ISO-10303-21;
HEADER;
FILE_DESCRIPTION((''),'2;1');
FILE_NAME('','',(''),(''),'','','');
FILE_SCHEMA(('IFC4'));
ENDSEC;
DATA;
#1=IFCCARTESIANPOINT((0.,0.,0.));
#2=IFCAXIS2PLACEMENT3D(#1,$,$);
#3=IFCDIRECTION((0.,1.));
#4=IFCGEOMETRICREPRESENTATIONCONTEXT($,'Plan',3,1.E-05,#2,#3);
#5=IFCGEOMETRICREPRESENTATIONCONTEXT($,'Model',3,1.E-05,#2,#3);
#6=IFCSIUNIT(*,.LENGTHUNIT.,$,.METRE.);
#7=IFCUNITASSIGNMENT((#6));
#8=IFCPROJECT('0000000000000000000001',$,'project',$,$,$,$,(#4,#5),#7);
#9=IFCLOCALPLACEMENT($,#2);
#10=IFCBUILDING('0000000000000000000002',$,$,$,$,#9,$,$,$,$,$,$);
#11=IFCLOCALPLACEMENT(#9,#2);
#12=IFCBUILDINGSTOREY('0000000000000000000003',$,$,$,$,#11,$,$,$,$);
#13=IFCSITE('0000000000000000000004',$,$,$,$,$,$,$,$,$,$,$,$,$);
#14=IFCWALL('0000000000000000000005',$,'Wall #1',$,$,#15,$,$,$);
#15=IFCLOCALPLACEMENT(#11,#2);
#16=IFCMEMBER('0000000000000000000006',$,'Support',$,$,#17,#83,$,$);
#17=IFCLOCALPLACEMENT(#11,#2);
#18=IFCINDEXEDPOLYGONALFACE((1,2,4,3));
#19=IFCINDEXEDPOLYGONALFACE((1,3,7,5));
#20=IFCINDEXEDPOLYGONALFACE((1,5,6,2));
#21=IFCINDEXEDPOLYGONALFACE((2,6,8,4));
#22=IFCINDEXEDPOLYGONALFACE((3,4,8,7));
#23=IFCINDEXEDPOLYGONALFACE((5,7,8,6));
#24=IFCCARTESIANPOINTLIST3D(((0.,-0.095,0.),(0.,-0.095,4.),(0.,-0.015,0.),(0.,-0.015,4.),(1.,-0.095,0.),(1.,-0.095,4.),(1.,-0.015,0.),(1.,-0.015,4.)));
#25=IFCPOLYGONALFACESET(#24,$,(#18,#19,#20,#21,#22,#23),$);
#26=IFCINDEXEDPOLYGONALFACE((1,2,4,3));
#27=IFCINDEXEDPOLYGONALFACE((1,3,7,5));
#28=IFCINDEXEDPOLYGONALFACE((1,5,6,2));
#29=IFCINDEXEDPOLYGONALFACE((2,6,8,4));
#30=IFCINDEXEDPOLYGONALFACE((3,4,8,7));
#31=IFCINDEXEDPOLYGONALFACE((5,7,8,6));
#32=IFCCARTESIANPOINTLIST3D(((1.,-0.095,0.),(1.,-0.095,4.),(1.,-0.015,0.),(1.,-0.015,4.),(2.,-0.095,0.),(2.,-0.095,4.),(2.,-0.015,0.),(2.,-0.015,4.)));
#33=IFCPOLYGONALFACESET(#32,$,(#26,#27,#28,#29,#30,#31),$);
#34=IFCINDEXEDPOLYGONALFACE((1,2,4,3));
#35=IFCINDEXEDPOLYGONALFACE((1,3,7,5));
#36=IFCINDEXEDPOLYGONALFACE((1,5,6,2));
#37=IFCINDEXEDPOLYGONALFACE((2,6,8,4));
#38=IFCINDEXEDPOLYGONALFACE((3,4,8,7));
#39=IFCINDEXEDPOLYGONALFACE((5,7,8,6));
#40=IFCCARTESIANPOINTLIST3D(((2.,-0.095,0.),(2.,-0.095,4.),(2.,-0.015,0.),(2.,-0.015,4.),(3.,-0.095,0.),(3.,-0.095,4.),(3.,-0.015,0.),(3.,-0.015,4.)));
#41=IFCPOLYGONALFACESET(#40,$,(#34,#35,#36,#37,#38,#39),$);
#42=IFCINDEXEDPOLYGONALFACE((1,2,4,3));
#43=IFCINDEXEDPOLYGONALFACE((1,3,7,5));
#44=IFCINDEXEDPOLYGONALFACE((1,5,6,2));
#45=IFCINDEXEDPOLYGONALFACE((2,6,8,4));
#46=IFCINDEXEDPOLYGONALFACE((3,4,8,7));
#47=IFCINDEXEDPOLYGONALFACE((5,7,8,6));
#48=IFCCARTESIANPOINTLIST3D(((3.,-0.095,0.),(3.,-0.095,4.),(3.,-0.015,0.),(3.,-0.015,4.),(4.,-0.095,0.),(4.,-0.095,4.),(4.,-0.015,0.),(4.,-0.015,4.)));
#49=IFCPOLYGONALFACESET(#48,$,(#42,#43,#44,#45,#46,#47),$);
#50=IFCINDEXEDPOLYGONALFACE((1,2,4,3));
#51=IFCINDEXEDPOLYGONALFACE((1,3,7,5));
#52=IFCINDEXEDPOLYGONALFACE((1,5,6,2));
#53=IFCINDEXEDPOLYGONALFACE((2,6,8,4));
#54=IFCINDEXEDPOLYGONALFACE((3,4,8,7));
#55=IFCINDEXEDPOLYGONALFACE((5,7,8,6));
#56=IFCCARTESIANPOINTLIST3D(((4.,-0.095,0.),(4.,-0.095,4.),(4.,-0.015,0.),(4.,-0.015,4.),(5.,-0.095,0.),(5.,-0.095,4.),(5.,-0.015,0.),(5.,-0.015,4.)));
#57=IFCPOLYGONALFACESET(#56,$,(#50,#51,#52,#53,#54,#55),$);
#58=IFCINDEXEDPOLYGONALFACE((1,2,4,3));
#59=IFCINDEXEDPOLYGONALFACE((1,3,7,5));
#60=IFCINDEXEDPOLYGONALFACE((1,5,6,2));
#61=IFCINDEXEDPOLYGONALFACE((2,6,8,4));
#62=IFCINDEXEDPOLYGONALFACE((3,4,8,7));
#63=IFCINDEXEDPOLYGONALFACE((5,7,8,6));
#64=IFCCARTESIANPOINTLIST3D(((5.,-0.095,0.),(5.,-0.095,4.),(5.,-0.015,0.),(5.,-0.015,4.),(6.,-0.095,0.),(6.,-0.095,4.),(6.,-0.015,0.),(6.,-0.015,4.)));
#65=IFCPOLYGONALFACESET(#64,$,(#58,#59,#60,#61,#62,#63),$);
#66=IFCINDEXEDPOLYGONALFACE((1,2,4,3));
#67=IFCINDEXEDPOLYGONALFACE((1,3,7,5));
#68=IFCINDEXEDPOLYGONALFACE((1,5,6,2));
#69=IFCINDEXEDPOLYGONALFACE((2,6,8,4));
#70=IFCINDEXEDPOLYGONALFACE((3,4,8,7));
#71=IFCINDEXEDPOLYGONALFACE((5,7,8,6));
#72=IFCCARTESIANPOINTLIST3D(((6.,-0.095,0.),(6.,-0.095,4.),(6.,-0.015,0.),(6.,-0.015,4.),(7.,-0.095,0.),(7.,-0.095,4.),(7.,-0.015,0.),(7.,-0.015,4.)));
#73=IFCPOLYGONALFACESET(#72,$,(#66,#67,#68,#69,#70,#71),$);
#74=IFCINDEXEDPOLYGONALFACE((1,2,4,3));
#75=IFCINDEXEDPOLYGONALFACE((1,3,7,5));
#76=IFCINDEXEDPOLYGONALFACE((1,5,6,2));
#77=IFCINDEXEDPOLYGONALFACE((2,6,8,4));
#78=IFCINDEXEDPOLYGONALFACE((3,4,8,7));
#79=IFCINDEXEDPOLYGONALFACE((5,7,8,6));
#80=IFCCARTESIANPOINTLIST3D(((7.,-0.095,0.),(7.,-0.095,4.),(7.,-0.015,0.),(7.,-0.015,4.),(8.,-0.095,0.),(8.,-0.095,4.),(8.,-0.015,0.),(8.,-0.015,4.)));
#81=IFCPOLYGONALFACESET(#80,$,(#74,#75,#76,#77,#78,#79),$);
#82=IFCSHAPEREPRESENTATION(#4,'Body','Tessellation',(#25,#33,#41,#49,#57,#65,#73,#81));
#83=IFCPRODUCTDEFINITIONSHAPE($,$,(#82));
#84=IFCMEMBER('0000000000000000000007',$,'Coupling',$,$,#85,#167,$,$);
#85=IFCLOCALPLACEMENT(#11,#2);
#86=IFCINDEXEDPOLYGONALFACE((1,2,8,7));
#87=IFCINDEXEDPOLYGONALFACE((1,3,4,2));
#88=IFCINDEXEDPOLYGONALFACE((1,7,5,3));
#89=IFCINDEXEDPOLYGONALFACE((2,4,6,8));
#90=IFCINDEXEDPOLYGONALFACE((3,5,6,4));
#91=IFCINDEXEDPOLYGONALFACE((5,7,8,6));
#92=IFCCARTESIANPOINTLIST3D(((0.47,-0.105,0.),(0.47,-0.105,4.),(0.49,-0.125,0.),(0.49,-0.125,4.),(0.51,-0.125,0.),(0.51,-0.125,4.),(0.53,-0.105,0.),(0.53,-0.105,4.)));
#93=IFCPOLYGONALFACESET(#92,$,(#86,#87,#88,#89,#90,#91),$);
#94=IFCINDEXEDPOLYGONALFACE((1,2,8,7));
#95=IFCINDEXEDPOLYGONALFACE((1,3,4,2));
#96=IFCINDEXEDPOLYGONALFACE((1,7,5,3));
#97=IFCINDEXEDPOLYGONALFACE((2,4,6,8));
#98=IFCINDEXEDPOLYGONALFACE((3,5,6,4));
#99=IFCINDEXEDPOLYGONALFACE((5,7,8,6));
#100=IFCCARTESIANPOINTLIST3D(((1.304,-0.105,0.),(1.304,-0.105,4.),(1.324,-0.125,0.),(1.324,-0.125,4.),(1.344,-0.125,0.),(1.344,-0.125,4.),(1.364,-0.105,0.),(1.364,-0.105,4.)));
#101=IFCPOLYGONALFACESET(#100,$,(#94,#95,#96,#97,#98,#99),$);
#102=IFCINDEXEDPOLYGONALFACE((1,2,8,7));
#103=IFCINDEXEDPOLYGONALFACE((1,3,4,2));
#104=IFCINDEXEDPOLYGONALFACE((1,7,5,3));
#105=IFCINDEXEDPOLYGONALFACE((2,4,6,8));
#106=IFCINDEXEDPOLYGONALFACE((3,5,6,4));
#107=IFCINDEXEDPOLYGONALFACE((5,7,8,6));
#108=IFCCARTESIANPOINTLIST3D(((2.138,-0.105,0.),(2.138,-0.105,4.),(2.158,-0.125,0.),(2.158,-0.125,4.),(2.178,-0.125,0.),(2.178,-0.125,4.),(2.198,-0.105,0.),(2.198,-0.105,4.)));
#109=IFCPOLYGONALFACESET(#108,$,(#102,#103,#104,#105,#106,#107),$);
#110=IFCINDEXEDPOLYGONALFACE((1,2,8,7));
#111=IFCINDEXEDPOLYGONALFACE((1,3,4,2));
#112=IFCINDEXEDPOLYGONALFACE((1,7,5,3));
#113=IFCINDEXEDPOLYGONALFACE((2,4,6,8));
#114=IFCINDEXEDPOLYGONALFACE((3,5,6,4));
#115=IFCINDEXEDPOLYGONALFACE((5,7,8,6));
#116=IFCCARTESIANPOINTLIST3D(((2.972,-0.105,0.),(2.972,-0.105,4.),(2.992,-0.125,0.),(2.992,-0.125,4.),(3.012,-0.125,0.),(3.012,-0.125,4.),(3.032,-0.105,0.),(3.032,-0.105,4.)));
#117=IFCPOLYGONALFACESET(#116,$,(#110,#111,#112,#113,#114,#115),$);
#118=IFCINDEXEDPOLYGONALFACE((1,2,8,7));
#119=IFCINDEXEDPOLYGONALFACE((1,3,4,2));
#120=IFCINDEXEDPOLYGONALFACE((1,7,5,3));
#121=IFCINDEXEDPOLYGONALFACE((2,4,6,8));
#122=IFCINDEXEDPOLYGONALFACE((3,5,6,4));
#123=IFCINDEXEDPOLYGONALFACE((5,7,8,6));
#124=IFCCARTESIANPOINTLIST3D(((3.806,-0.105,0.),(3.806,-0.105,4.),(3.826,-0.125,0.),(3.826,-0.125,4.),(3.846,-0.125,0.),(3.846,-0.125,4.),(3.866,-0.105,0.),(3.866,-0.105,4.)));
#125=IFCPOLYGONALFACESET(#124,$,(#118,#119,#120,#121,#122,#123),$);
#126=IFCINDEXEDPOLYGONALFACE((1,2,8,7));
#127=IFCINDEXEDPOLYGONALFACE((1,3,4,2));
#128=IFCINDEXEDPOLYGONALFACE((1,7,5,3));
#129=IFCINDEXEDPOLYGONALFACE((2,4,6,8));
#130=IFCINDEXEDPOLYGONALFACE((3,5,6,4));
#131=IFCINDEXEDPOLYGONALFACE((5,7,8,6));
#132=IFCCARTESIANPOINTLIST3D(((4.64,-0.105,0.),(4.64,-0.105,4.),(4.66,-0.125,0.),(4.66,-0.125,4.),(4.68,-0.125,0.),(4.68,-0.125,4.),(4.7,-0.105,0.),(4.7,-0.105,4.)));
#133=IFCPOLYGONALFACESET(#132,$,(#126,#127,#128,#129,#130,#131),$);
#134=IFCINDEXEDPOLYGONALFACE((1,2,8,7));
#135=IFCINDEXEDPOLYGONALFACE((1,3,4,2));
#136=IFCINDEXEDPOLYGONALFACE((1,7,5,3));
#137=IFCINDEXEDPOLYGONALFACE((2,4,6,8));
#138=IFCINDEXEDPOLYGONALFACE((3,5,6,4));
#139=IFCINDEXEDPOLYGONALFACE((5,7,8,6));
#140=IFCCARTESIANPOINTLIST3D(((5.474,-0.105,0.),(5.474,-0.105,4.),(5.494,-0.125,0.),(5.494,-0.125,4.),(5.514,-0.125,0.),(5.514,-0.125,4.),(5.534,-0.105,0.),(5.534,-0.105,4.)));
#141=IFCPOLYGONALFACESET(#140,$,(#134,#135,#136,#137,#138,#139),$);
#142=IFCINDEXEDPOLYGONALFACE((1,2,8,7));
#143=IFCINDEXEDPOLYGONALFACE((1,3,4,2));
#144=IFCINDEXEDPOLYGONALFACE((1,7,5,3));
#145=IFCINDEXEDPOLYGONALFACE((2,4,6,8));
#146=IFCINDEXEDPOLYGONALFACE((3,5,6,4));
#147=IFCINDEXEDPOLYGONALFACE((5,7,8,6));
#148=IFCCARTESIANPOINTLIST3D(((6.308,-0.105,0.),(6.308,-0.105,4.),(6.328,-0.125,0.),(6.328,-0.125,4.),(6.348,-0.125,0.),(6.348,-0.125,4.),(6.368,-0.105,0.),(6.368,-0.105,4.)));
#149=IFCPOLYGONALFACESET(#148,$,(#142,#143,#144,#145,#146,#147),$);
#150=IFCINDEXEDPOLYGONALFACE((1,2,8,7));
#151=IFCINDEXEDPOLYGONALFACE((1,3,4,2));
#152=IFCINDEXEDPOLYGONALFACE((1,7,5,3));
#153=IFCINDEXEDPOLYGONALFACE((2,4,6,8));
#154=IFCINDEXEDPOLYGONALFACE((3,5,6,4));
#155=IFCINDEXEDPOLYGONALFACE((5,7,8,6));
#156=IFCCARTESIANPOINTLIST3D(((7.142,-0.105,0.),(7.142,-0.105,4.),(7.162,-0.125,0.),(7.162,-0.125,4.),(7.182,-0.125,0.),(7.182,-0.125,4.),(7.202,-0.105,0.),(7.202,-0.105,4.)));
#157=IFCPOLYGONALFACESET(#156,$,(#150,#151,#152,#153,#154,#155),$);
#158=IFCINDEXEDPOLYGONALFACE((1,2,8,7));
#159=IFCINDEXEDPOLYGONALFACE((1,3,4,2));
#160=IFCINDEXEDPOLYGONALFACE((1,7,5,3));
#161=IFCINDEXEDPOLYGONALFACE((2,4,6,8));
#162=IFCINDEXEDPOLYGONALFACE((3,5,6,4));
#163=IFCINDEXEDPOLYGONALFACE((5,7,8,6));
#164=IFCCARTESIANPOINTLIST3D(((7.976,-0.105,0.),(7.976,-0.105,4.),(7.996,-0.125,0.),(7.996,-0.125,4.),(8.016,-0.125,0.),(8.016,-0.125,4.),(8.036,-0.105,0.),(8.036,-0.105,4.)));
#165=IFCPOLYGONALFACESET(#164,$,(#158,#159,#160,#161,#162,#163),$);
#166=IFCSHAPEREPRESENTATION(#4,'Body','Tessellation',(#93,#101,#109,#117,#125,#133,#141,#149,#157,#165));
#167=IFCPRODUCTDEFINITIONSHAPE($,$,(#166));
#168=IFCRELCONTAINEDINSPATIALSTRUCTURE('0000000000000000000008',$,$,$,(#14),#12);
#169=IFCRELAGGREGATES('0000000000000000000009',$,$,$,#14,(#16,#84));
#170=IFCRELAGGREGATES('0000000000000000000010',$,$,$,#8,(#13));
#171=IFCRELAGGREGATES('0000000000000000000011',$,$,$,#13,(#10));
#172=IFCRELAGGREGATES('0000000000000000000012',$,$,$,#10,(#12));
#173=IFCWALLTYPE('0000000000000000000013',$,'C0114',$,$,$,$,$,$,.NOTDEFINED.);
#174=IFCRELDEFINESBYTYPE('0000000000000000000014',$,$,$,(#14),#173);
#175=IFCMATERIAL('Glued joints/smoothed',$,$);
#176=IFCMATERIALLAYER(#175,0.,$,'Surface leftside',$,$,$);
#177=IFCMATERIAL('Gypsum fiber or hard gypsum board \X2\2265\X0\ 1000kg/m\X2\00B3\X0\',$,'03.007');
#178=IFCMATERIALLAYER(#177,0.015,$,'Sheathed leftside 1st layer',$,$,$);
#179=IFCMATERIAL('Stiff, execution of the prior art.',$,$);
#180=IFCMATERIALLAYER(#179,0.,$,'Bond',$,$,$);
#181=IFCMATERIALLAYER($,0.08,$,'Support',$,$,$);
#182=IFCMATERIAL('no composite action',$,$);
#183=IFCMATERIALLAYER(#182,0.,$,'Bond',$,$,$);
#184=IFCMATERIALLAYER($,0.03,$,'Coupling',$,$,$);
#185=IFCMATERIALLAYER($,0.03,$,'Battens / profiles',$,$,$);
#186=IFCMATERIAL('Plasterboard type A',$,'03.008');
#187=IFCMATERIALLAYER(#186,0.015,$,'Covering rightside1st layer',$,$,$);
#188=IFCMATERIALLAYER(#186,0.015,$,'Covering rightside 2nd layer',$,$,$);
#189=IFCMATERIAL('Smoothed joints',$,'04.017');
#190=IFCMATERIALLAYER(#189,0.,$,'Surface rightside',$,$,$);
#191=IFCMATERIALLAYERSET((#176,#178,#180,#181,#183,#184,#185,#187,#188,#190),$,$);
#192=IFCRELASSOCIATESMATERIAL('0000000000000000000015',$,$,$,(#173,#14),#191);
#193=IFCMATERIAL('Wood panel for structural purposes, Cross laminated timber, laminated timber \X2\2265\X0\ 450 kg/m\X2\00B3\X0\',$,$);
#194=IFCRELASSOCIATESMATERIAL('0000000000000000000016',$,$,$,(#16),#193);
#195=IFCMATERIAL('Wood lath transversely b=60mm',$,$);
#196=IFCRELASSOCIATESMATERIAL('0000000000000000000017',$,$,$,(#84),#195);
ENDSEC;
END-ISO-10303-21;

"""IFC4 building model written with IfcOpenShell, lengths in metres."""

from ifc_helpers import new_model, si_unit, direction, frame, frame_2d, origin, place, context, project, spatial, polyline, rectangle, outline, extrude, material, layer, layer_set, type_object, element, aggregate, save


model = new_model("IFC4")

# Units and contexts
plan_context = context("Plan", 3, precision=1e-05, world=origin(), true_north=direction((0.0, 1.0)))
model_context = context("Model", 3, precision=1e-05, world=origin(), true_north=direction((0.0, 1.0)))
ifc_project = project(units=[si_unit("LENGTHUNIT", "METRE")], contexts=[plan_context, model_context])

# Site, building, storey
site = spatial("IfcSite", under=ifc_project)
building_placement = place(None, origin())
building = spatial("IfcBuilding", under=site, at=building_placement)
storey_placement = place(building_placement, origin())
storey = spatial("IfcBuildingStorey", under=building, at=storey_placement)

# Wall, members
ifc_material_1 = material(Name="Glued joints/smoothed")
ifc_layer_1 = layer(ifc_material_1, 0.0, Name="Surface leftside")
ifc_material_2 = material(Name="Gypsum fiber or hard gypsum board ≥ 1000kg/m³", Category="03.007")
ifc_layer_2 = layer(ifc_material_2, 0.015, Name="Sheathed leftside 1st layer")
ifc_material_3 = material(Name="Stiff, execution of the prior art.")
ifc_layer_3 = layer(ifc_material_3, 0.0, Name="Bond")
ifc_layer_4 = layer(None, 0.08, Name="Support")
ifc_material_4 = material(Name="no composite action")
ifc_layer_5 = layer(ifc_material_4, 0.0, Name="Bond")
ifc_layer_6 = layer(None, 0.03, Name="Coupling")
ifc_layer_7 = layer(None, 0.03, Name="Battens / profiles")
ifc_material_5 = material(Name="Plasterboard type A", Category="03.008")
ifc_layer_8 = layer(ifc_material_5, 0.015, Name="Covering rightside1st layer")
ifc_layer_9 = layer(ifc_material_5, 0.015, Name="Covering rightside 2nd layer")
ifc_material_6 = material(Name="Smoothed joints", Category="04.017")
ifc_layer_10 = layer(ifc_material_6, 0.0, Name="Surface rightside")
ifc_layer_set = layer_set([ifc_layer_1, ifc_layer_2, ifc_layer_3, ifc_layer_4, ifc_layer_5, ifc_layer_6, ifc_layer_7, ifc_layer_8, ifc_layer_9, ifc_layer_10])
wall_type = type_object("IfcWallType", Name="C0114", PredefinedType="NOTDEFINED", material=ifc_layer_set)
wall_placement = place(None, frame((0.0, 0.0, 0.0), z_axis=(0.0, -1.0, 0.0), x_axis=(1.0, 0.0, 0.0)))
wall = element("IfcWall", 1, at=wall_placement, inside=storey, type_object=wall_type, material=ifc_layer_set, Name="Wall #1")
ifc_material_7 = material(Name="Wood panel for structural purposes, Cross laminated timber, laminated timber ≥ 450 kg/m³")
member_1_placement = place(wall_placement, origin())
member_1 = element("IfcMember", 2, at=member_1_placement, material=ifc_material_7, Name="Support", context=plan_context, shape_type="SweptSolid", body=[
    extrude(rectangle(XDim=1.0, YDim=0.08, at=frame_2d((0.5, 0.04), x_axis=(1.0, 0.0))), frame((0.0, 4.0, 0.015), z_axis=(0.0, -1.0, 0.0), x_axis=(1.0, 0.0, 0.0)), (0.0, 0.0, 1.0), 4.0),
    extrude(rectangle(XDim=1.0, YDim=0.08, at=frame_2d((0.5, 0.04), x_axis=(1.0, 0.0))), frame((1.0, 4.0, 0.015), z_axis=(0.0, -1.0, 0.0), x_axis=(1.0, 0.0, 0.0)), (0.0, 0.0, 1.0), 4.0),
    extrude(rectangle(XDim=1.0, YDim=0.08, at=frame_2d((0.5, 0.04), x_axis=(1.0, 0.0))), frame((2.0, 4.0, 0.015), z_axis=(0.0, -1.0, 0.0), x_axis=(1.0, 0.0, 0.0)), (0.0, 0.0, 1.0), 4.0),
    extrude(rectangle(XDim=1.0, YDim=0.08, at=frame_2d((0.5, 0.04), x_axis=(1.0, 0.0))), frame((3.0, 4.0, 0.015), z_axis=(0.0, -1.0, 0.0), x_axis=(1.0, 0.0, 0.0)), (0.0, 0.0, 1.0), 4.0),
    extrude(rectangle(XDim=1.0, YDim=0.08, at=frame_2d((0.5, 0.04), x_axis=(1.0, 0.0))), frame((4.0, 4.0, 0.015), z_axis=(0.0, -1.0, 0.0), x_axis=(1.0, 0.0, 0.0)), (0.0, 0.0, 1.0), 4.0),
    extrude(rectangle(XDim=1.0, YDim=0.08, at=frame_2d((0.5, 0.04), x_axis=(1.0, 0.0))), frame((5.0, 4.0, 0.015), z_axis=(0.0, -1.0, 0.0), x_axis=(1.0, 0.0, 0.0)), (0.0, 0.0, 1.0), 4.0),
    extrude(rectangle(XDim=1.0, YDim=0.08, at=frame_2d((0.5, 0.04), x_axis=(1.0, 0.0))), frame((6.0, 4.0, 0.015), z_axis=(0.0, -1.0, 0.0), x_axis=(1.0, 0.0, 0.0)), (0.0, 0.0, 1.0), 4.0),
    extrude(rectangle(XDim=1.0, YDim=0.08, at=frame_2d((0.5, 0.04), x_axis=(1.0, 0.0))), frame((7.0, 4.0, 0.015), z_axis=(0.0, -1.0, 0.0), x_axis=(1.0, 0.0, 0.0)), (0.0, 0.0, 1.0), 4.0),
])
ifc_material_8 = material(Name="Wood lath transversely b=60mm")
member_2_placement = place(wall_placement, origin())
member_2 = element("IfcMember", 3, at=member_2_placement, material=ifc_material_8, Name="Coupling", context=plan_context, shape_type="SweptSolid", body=[
    extrude(outline(polyline([(0.0, 0.0), (0.06, 0.0), (0.04, 0.02), (0.02, 0.02), (0.0, 0.0)])), frame((0.47, 4.0, 0.105), z_axis=(0.0, -1.0, 0.0), x_axis=(1.0, 0.0, 0.0)), (0.0, 0.0, 1.0), 4.0),
    extrude(outline(polyline([(0.0, 0.0), (0.06, 0.0), (0.04, 0.02), (0.02, 0.02), (0.0, 0.0)])), frame((1.304, 4.0, 0.105), z_axis=(0.0, -1.0, 0.0), x_axis=(1.0, 0.0, 0.0)), (0.0, 0.0, 1.0), 4.0),
    extrude(outline(polyline([(0.0, 0.0), (0.06, 0.0), (0.04, 0.02), (0.02, 0.02), (0.0, 0.0)])), frame((2.138, 4.0, 0.105), z_axis=(0.0, -1.0, 0.0), x_axis=(1.0, 0.0, 0.0)), (0.0, 0.0, 1.0), 4.0),
    extrude(outline(polyline([(0.0, 0.0), (0.06, 0.0), (0.04, 0.02), (0.02, 0.02), (0.0, 0.0)])), frame((2.972, 4.0, 0.105), z_axis=(0.0, -1.0, 0.0), x_axis=(1.0, 0.0, 0.0)), (0.0, 0.0, 1.0), 4.0),
    extrude(outline(polyline([(0.0, 0.0), (0.06, 0.0), (0.04, 0.02), (0.02, 0.02), (0.0, 0.0)])), frame((3.806, 4.0, 0.105), z_axis=(0.0, -1.0, 0.0), x_axis=(1.0, 0.0, 0.0)), (0.0, 0.0, 1.0), 4.0),
    extrude(outline(polyline([(0.0, 0.0), (0.06, 0.0), (0.04, 0.02), (0.02, 0.02), (0.0, 0.0)])), frame((4.64, 4.0, 0.105), z_axis=(0.0, -1.0, 0.0), x_axis=(1.0, 0.0, 0.0)), (0.0, 0.0, 1.0), 4.0),
    extrude(outline(polyline([(0.0, 0.0), (0.06, 0.0), (0.04, 0.02), (0.02, 0.02), (0.0, 0.0)])), frame((5.474, 4.0, 0.105), z_axis=(0.0, -1.0, 0.0), x_axis=(1.0, 0.0, 0.0)), (0.0, 0.0, 1.0), 4.0),
    extrude(outline(polyline([(0.0, 0.0), (0.06, 0.0), (0.04, 0.02), (0.02, 0.02), (0.0, 0.0)])), frame((6.308, 4.0, 0.105), z_axis=(0.0, -1.0, 0.0), x_axis=(1.0, 0.0, 0.0)), (0.0, 0.0, 1.0), 4.0),
    extrude(outline(polyline([(0.0, 0.0), (0.06, 0.0), (0.04, 0.02), (0.02, 0.02), (0.0, 0.0)])), frame((7.142, 4.0, 0.105), z_axis=(0.0, -1.0, 0.0), x_axis=(1.0, 0.0, 0.0)), (0.0, 0.0, 1.0), 4.0),
    extrude(outline(polyline([(0.0, 0.0), (0.06, 0.0), (0.04, 0.02), (0.02, 0.02), (0.0, 0.0)])), frame((7.976, 4.0, 0.105), z_axis=(0.0, -1.0, 0.0), x_axis=(1.0, 0.0, 0.0)), (0.0, 0.0, 1.0), 4.0),
])
aggregate(wall, [member_1, member_2])

save(model, "model.ifc")
